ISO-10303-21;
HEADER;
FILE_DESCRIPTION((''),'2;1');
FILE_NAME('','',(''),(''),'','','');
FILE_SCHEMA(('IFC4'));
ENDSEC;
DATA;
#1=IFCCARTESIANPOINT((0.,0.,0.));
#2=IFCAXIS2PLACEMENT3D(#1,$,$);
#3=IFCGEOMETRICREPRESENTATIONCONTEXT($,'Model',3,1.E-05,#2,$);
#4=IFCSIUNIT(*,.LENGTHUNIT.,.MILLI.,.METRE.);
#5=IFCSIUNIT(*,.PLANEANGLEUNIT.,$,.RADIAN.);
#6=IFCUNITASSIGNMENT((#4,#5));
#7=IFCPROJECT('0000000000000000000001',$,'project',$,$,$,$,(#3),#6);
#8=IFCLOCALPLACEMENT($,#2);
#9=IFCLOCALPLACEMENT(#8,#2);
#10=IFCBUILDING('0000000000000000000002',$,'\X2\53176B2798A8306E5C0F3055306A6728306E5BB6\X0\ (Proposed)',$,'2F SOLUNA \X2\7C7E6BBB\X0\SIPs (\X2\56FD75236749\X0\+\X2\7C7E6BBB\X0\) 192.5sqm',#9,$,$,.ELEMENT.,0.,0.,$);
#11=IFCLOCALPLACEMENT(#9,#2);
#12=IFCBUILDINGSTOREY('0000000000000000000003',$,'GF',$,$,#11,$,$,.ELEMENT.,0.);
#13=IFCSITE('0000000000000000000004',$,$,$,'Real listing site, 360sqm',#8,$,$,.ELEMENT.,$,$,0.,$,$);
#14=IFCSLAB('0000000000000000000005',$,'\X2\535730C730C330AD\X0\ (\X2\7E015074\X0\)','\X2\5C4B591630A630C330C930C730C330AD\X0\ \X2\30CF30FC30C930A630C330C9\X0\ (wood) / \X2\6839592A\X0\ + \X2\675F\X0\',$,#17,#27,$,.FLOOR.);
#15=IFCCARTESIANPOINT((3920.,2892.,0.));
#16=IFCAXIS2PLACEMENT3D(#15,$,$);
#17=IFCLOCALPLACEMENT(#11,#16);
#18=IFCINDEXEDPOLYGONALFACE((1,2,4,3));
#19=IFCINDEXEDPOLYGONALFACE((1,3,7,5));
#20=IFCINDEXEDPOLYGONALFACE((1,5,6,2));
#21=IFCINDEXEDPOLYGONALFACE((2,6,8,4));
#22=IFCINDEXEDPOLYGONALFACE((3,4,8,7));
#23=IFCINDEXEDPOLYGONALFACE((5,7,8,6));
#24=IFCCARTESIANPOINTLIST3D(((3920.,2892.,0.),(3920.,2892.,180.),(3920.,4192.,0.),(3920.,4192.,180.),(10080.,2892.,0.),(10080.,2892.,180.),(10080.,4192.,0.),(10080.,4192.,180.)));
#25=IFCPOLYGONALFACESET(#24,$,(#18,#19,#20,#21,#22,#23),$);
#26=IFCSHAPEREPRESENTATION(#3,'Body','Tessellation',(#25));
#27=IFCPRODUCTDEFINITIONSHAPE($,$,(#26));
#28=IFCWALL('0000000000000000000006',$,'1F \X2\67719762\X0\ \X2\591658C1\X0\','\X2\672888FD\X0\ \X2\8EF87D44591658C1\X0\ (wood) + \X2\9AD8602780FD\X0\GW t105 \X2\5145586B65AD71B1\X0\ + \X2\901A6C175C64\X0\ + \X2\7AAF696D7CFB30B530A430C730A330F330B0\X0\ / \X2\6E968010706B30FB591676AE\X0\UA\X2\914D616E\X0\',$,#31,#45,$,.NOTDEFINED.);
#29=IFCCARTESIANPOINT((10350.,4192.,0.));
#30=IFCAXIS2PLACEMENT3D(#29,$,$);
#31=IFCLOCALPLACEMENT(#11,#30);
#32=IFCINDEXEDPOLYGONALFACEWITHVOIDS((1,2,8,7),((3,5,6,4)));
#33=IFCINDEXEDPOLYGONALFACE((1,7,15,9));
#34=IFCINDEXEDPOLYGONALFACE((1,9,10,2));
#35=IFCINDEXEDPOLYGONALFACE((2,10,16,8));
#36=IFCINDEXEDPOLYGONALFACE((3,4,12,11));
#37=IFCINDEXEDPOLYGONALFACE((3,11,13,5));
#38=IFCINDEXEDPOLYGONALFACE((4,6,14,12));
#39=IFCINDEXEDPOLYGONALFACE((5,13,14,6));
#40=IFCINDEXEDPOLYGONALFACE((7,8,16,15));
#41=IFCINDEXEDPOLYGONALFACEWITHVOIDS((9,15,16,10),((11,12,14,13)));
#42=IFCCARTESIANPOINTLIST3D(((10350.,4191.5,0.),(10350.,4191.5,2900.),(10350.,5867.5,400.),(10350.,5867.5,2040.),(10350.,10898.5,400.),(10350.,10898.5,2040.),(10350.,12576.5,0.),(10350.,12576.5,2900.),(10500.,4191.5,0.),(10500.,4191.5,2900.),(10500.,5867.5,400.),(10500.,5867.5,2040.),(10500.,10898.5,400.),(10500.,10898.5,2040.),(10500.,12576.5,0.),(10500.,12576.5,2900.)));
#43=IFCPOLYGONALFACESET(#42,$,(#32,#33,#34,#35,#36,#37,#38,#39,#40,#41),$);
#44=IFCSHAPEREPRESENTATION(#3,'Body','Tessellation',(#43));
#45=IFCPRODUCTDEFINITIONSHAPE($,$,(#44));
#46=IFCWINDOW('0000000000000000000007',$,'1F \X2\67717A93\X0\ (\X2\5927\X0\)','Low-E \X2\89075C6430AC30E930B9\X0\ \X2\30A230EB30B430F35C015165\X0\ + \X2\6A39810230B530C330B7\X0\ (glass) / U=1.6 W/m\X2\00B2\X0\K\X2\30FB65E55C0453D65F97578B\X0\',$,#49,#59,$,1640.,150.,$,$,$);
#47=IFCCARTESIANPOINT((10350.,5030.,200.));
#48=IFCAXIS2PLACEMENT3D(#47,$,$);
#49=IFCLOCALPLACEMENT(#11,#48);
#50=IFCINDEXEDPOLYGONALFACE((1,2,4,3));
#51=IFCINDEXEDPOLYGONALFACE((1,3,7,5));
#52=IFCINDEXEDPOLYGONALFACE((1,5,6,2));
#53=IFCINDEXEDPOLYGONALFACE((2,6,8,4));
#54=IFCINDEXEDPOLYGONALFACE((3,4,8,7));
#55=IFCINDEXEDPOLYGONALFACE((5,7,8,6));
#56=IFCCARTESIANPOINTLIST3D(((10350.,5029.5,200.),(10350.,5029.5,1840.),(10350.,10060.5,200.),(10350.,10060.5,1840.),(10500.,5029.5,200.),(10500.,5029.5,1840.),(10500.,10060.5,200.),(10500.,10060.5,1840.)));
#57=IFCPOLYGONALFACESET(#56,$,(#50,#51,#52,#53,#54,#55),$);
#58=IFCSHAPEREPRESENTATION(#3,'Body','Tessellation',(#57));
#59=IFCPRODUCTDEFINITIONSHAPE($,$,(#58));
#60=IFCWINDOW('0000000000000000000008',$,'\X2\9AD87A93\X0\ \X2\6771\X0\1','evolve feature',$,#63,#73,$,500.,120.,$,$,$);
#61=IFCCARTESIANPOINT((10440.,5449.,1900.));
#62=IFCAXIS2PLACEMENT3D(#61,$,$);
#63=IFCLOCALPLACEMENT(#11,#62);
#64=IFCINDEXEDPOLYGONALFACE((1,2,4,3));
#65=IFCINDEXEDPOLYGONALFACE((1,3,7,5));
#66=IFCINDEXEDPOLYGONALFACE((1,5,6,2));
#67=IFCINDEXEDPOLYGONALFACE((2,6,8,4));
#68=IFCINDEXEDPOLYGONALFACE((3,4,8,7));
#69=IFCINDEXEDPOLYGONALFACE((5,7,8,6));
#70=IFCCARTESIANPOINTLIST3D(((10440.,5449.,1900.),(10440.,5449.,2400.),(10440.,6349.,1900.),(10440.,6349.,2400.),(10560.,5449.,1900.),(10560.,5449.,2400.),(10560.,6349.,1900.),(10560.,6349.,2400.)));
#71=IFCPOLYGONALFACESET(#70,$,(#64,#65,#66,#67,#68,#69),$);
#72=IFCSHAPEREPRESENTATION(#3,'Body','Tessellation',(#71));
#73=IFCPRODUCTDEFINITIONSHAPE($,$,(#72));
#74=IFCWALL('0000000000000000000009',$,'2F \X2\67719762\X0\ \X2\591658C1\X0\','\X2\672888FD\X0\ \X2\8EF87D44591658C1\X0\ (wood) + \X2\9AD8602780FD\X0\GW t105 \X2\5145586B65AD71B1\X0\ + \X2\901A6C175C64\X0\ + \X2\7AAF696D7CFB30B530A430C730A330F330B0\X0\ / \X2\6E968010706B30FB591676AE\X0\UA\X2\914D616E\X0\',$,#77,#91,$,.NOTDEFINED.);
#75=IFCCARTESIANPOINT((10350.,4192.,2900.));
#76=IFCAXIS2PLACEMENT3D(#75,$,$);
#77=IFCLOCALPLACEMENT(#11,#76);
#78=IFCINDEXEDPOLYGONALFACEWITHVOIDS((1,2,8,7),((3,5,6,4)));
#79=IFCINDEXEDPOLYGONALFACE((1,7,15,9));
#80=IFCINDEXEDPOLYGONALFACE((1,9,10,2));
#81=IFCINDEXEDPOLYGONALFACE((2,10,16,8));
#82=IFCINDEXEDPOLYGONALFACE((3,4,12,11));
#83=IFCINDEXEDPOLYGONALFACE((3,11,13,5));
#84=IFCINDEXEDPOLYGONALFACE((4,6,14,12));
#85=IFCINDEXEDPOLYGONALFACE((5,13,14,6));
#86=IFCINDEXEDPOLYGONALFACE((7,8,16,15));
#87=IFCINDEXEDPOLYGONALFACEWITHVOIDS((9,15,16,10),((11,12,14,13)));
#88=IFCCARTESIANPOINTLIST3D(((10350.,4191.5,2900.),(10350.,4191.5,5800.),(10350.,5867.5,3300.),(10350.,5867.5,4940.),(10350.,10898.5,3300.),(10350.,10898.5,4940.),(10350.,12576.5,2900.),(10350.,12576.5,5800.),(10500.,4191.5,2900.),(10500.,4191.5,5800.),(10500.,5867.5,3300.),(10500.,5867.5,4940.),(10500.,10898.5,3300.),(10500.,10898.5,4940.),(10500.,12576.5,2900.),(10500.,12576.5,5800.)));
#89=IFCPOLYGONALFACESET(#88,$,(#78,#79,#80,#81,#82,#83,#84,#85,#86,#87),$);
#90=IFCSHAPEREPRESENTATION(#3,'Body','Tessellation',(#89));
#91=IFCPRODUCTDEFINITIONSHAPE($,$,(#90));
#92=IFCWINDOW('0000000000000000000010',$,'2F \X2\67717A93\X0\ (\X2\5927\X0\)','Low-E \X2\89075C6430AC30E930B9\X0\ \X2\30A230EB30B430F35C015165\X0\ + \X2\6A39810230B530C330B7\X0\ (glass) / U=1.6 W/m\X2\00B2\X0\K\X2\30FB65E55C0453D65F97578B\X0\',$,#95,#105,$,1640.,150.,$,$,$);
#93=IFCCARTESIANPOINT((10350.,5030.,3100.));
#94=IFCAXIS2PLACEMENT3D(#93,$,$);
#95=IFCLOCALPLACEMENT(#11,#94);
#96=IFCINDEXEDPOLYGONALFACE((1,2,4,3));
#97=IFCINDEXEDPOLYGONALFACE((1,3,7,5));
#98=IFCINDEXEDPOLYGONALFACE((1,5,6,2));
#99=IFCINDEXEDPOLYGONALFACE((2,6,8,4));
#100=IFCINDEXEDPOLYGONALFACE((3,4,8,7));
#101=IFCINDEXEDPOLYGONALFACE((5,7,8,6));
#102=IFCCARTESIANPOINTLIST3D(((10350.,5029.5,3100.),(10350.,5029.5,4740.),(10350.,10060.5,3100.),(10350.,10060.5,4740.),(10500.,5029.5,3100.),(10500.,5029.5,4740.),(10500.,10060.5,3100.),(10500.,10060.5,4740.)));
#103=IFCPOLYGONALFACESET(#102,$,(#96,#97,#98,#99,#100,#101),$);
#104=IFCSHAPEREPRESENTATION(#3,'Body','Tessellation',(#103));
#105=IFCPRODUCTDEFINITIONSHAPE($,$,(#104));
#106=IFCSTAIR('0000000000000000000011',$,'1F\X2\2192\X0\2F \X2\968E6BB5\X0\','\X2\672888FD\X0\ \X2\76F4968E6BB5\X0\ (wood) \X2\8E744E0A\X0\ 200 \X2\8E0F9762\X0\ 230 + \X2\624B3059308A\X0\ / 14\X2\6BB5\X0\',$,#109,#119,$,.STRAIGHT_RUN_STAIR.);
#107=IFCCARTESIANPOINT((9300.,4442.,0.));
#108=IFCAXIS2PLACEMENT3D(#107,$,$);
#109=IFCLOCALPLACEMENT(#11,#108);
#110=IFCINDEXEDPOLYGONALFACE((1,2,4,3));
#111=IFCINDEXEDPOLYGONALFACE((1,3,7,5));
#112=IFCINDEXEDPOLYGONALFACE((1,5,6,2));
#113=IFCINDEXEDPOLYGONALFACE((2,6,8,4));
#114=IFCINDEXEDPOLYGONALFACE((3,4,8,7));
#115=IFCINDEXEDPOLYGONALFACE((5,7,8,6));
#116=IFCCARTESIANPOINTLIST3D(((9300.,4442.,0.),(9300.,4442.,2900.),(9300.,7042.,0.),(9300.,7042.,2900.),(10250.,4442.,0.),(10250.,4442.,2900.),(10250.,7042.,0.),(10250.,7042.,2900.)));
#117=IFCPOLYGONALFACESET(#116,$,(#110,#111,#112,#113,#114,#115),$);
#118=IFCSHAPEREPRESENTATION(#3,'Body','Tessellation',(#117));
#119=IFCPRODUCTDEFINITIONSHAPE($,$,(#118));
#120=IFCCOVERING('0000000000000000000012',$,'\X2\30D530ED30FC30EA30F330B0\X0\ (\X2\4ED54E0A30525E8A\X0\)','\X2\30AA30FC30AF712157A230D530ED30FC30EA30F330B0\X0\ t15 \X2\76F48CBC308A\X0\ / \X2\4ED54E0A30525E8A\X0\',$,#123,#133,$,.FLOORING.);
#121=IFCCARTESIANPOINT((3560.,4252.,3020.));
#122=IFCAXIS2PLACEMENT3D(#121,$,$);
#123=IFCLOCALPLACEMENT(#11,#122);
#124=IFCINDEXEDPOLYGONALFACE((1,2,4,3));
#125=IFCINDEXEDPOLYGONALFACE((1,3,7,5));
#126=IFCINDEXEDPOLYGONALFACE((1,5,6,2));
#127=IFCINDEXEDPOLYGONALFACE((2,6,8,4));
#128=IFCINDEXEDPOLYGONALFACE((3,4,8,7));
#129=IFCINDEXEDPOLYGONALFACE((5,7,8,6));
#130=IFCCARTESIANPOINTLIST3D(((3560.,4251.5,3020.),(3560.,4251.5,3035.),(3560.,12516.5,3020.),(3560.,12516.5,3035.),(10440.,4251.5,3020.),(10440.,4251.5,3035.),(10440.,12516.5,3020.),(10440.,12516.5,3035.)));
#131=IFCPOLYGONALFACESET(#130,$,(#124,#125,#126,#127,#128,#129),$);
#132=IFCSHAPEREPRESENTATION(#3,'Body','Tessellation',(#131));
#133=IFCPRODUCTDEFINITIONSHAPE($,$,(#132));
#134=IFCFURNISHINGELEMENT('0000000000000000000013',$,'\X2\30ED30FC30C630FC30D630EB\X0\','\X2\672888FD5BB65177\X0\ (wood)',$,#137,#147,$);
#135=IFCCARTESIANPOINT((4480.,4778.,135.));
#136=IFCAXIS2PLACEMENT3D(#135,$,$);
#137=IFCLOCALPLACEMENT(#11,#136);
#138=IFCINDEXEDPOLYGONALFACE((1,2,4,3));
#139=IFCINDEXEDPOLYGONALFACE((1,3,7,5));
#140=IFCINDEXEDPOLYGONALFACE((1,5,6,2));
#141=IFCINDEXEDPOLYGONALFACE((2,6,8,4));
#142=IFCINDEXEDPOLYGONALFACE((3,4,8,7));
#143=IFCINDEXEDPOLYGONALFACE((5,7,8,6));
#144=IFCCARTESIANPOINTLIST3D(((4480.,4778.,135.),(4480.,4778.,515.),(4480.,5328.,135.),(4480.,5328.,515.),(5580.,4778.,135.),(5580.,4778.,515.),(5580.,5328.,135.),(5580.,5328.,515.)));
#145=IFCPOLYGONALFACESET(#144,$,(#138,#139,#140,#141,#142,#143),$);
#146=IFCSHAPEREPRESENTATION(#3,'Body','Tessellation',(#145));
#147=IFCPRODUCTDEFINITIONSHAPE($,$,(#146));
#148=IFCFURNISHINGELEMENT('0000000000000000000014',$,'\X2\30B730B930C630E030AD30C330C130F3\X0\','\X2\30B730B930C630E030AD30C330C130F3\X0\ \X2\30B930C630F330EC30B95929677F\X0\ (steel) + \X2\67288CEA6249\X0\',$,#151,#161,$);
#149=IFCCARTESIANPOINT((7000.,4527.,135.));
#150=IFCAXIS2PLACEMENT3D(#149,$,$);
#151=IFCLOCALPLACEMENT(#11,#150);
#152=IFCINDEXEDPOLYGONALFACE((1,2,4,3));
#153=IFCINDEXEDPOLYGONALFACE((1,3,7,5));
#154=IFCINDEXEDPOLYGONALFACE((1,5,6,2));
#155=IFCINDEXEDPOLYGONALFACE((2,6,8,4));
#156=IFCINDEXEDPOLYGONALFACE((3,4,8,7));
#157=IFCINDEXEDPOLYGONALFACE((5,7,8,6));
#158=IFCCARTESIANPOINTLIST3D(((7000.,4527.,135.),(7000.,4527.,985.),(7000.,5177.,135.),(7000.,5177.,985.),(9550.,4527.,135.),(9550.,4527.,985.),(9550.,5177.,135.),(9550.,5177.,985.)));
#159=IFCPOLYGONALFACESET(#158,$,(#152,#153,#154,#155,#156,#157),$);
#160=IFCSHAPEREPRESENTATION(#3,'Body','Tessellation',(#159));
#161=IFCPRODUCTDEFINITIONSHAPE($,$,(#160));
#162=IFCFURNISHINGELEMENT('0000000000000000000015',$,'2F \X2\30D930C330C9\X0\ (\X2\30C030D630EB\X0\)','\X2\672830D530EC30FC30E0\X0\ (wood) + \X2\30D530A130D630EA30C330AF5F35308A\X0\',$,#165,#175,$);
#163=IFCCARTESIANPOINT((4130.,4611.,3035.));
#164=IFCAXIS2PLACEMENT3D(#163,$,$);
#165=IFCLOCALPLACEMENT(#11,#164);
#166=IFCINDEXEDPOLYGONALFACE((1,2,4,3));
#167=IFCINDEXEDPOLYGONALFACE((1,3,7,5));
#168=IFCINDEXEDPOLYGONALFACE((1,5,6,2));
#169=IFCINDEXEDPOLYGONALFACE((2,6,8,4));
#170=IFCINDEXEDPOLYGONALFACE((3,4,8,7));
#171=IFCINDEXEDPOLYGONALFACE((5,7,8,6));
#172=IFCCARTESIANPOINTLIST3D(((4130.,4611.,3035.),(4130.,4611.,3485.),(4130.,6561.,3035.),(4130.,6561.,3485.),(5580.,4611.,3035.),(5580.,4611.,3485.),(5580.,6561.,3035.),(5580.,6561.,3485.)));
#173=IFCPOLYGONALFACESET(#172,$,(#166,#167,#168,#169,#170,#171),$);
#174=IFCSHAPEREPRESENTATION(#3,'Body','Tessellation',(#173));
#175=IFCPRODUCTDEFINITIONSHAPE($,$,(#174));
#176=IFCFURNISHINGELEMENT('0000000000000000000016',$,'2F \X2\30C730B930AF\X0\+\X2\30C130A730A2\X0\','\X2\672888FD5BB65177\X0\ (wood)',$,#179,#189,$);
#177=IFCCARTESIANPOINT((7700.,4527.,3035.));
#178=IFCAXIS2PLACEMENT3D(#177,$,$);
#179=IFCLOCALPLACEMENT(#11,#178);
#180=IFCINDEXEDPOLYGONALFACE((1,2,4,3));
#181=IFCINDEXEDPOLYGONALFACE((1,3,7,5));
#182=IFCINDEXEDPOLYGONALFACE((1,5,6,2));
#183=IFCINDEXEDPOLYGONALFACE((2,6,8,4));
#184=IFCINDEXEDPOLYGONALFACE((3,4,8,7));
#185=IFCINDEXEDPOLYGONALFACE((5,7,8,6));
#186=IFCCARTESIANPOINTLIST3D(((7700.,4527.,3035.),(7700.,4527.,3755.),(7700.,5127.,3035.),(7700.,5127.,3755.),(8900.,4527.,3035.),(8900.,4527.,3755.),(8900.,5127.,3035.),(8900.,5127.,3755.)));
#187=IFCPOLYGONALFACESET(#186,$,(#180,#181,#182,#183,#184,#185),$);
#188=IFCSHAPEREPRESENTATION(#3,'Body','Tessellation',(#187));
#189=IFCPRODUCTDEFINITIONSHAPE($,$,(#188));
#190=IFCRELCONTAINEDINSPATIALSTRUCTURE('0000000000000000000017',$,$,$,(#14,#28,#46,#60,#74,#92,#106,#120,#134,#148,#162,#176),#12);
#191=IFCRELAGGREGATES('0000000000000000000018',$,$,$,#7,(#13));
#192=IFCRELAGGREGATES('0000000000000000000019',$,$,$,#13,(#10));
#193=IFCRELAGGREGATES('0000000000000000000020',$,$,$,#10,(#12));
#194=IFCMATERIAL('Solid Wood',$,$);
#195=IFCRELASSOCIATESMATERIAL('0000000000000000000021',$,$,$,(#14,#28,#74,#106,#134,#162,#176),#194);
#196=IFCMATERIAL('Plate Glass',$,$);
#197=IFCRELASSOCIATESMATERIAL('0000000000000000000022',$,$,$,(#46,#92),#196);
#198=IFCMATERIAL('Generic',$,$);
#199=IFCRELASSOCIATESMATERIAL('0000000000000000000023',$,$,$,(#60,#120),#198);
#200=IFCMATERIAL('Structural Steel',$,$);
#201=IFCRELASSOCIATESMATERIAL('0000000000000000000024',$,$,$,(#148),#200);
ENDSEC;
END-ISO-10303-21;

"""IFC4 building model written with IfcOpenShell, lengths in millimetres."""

from ifc_helpers import new_model, si_unit, frame, frame_2d, origin, place, context, project, spatial, rectangle, extrude, material, element, fill, save


model = new_model("IFC4")

# Units and contexts
model_context = context("Model", 3, precision=1e-05, world=origin())
ifc_project = project(units=[si_unit("LENGTHUNIT", "METRE", prefix="MILLI"), si_unit("PLANEANGLEUNIT", "RADIAN")], contexts=[model_context])

# Site, building, storey
site_placement = place(None, origin())
site = spatial("IfcSite", under=ifc_project, at=site_placement, ObjectType="Real listing site, 360sqm", CompositionType="ELEMENT", RefElevation=0.0)
building_placement = place(site_placement, origin())
building = spatial("IfcBuilding", under=site, at=building_placement, Name="北欧風の小さな木の家 (Proposed)", ObjectType="2F SOLUNA 籾殻SIPs (国産杉+籾殻) 192.5sqm", CompositionType="ELEMENT", ElevationOfRefHeight=0.0, ElevationOfTerrain=0.0)
storey_placement = place(building_placement, origin())
storey = spatial("IfcBuildingStorey", under=building, at=storey_placement, Name="GF", CompositionType="ELEMENT", Elevation=0.0)

# Slab
ifc_material_1 = material(Name="Solid Wood")
slab_placement = place(storey_placement, frame((3920.0, 2892.0, 0.0)))
element("IfcSlab", 1, at=slab_placement, inside=storey, material=ifc_material_1, Name="南デッキ (縁側)", Description="屋外ウッドデッキ ハードウッド (wood) / 根太 + 束", PredefinedType="FLOOR", context=model_context, shape_type="SweptSolid", body=[
    extrude(rectangle(XDim=6160.0, YDim=1300.0, at=frame_2d((3080.0, 650.0))), frame((3920.0, 2892.0, 0.0)), (0.0, 0.0, 1.0), 180.0),
])

# Wall, openings, windows
wall_1_placement = place(storey_placement, frame((10350.0, 4192.0, 0.0)))
wall_1 = element("IfcWall", 2, at=wall_1_placement, inside=storey, material=ifc_material_1, Name="1F 東面 外壁", Description="木製 軸組外壁 (wood) + 高性能GW t105 充填断熱 + 通気層 + 窯業系サイディング / 準耐火・外皮UA配慮", PredefinedType="NOTDEFINED", context=model_context, shape_type="SweptSolid", body=[
    extrude(rectangle(XDim=150.0, YDim=8385.0, at=frame_2d((75.0, 4192.0))), frame((10350.0, 4192.0, 0.0)), (0.0, 0.0, 1.0), 2900.0),
])
opening_1_placement = place(storey_placement, frame((10350.0, 5030.0, 200.0)))
opening_1 = element("IfcOpeningElement", 3, at=opening_1_placement, cuts=wall_1, PredefinedType="NOTDEFINED", context=model_context, shape_type="SweptSolid", body=[
    extrude(rectangle(XDim=150.0, YDim=5031.0, at=frame_2d((75.0, 2515.0))), frame((10350.0, 5030.0, 200.0)), (0.0, 0.0, 1.0), 1640.0),
])
opening_2_placement = place(storey_placement, frame((10440.0, 5449.0, 1900.0)))
opening_2 = element("IfcOpeningElement", 4, at=opening_2_placement, cuts=wall_1, PredefinedType="NOTDEFINED", context=model_context, shape_type="SweptSolid", body=[
    extrude(rectangle(XDim=120.0, YDim=900.0, at=frame_2d((60.0, 450.0))), frame((10440.0, 5449.0, 1900.0)), (0.0, 0.0, 1.0), 500.0),
])
ifc_material_2 = material(Name="Plate Glass")
window_1_placement = place(storey_placement, frame((10350.0, 5030.0, 200.0)))
window_1 = element("IfcWindow", 5, at=window_1_placement, inside=storey, material=ifc_material_2, Name="1F 東窓 (大)", Description="Low-E 複層ガラス アルゴン封入 + 樹脂サッシ (glass) / U=1.6 W/m²K・日射取得型", OverallHeight=1640.0, OverallWidth=150.0, context=model_context, shape_type="SweptSolid", body=[
    extrude(rectangle(XDim=150.0, YDim=5031.0, at=frame_2d((75.0, 2515.0))), frame((10350.0, 5030.0, 200.0)), (0.0, 0.0, 1.0), 1640.0),
])
fill(opening_1, window_1)
ifc_material_3 = material(Name="Generic")
window_2_placement = place(storey_placement, frame((10440.0, 5449.0, 1900.0)))
window_2 = element("IfcWindow", 6, at=window_2_placement, inside=storey, material=ifc_material_3, Name="高窓 東1", Description="evolve feature", OverallHeight=500.0, OverallWidth=120.0, context=model_context, shape_type="SweptSolid", body=[
    extrude(rectangle(XDim=120.0, YDim=900.0, at=frame_2d((60.0, 450.0))), frame((10440.0, 5449.0, 1900.0)), (0.0, 0.0, 1.0), 500.0),
])
fill(opening_2, window_2)

# Wall, opening, window
wall_2_placement = place(storey_placement, frame((10350.0, 4192.0, 2900.0)))
wall_2 = element("IfcWall", 7, at=wall_2_placement, inside=storey, material=ifc_material_1, Name="2F 東面 外壁", Description="木製 軸組外壁 (wood) + 高性能GW t105 充填断熱 + 通気層 + 窯業系サイディング / 準耐火・外皮UA配慮", PredefinedType="NOTDEFINED", context=model_context, shape_type="SweptSolid", body=[
    extrude(rectangle(XDim=150.0, YDim=8385.0, at=frame_2d((75.0, 4192.0))), frame((10350.0, 4192.0, 2900.0)), (0.0, 0.0, 1.0), 2900.0),
])
opening_3_placement = place(storey_placement, frame((10350.0, 5030.0, 3100.0)))
opening_3 = element("IfcOpeningElement", 8, at=opening_3_placement, cuts=wall_2, PredefinedType="NOTDEFINED", context=model_context, shape_type="SweptSolid", body=[
    extrude(rectangle(XDim=150.0, YDim=5031.0, at=frame_2d((75.0, 2515.0))), frame((10350.0, 5030.0, 3100.0)), (0.0, 0.0, 1.0), 1640.0),
])
window_3_placement = place(storey_placement, frame((10350.0, 5030.0, 3100.0)))
window_3 = element("IfcWindow", 9, at=window_3_placement, inside=storey, material=ifc_material_2, Name="2F 東窓 (大)", Description="Low-E 複層ガラス アルゴン封入 + 樹脂サッシ (glass) / U=1.6 W/m²K・日射取得型", OverallHeight=1640.0, OverallWidth=150.0, context=model_context, shape_type="SweptSolid", body=[
    extrude(rectangle(XDim=150.0, YDim=5031.0, at=frame_2d((75.0, 2515.0))), frame((10350.0, 5030.0, 3100.0)), (0.0, 0.0, 1.0), 1640.0),
])
fill(opening_3, window_3)

# Stair
stair_placement = place(storey_placement, frame((9300.0, 4442.0, 0.0)))
element("IfcStair", 10, at=stair_placement, inside=storey, material=ifc_material_1, Name="1F→2F 階段", Description="木製 直階段 (wood) 蹴上 200 踏面 230 + 手すり / 14段", PredefinedType="STRAIGHT_RUN_STAIR", context=model_context, shape_type="SweptSolid", body=[
    extrude(rectangle(XDim=950.0, YDim=2600.0, at=frame_2d((475.0, 1300.0))), frame((9300.0, 4442.0, 0.0)), (0.0, 0.0, 1.0), 2900.0),
])

# Covering
covering_placement = place(storey_placement, frame((3560.0, 4252.0, 3020.0)))
element("IfcCovering", 11, at=covering_placement, inside=storey, material=ifc_material_3, Name="フローリング (仕上げ床)", Description="オーク無垢フローリング t15 直貼り / 仕上げ床", PredefinedType="FLOORING", context=model_context, shape_type="SweptSolid", body=[
    extrude(rectangle(XDim=6880.0, YDim=8265.0, at=frame_2d((3440.0, 4132.0))), frame((3560.0, 4252.0, 3020.0)), (0.0, 0.0, 1.0), 15.0),
])

# Furnishing elements
furnishing_1_placement = place(storey_placement, frame((4480.0, 4778.0, 135.0)))
element("IfcFurnishingElement", 12, at=furnishing_1_placement, inside=storey, material=ifc_material_1, Name="ローテーブル", Description="木製家具 (wood)", context=model_context, shape_type="SweptSolid", body=[
    extrude(rectangle(XDim=1100.0, YDim=550.0, at=frame_2d((550.0, 275.0))), frame((4480.0, 4778.0, 135.0)), (0.0, 0.0, 1.0), 380.0),
])
ifc_material_4 = material(Name="Structural Steel")
furnishing_2_placement = place(storey_placement, frame((7000.0, 4527.0, 135.0)))
element("IfcFurnishingElement", 13, at=furnishing_2_placement, inside=storey, material=ifc_material_4, Name="システムキッチン", Description="システムキッチン ステンレス天板 (steel) + 木質扉", context=model_context, shape_type="SweptSolid", body=[
    extrude(rectangle(XDim=2550.0, YDim=650.0, at=frame_2d((1275.0, 325.0))), frame((7000.0, 4527.0, 135.0)), (0.0, 0.0, 1.0), 850.0),
])
furnishing_3_placement = place(storey_placement, frame((4130.0, 4611.0, 3035.0)))
element("IfcFurnishingElement", 14, at=furnishing_3_placement, inside=storey, material=ifc_material_1, Name="2F ベッド (ダブル)", Description="木フレーム (wood) + ファブリック張り", context=model_context, shape_type="SweptSolid", body=[
    extrude(rectangle(XDim=1450.0, YDim=1950.0, at=frame_2d((725.0, 975.0))), frame((4130.0, 4611.0, 3035.0)), (0.0, 0.0, 1.0), 450.0),
])
furnishing_4_placement = place(storey_placement, frame((7700.0, 4527.0, 3035.0)))
element("IfcFurnishingElement", 15, at=furnishing_4_placement, inside=storey, material=ifc_material_1, Name="2F デスク+チェア", Description="木製家具 (wood)", context=model_context, shape_type="SweptSolid", body=[
    extrude(rectangle(XDim=1200.0, YDim=600.0, at=frame_2d((600.0, 300.0))), frame((7700.0, 4527.0, 3035.0)), (0.0, 0.0, 1.0), 720.0),
])

save(model, "model.ifc")
